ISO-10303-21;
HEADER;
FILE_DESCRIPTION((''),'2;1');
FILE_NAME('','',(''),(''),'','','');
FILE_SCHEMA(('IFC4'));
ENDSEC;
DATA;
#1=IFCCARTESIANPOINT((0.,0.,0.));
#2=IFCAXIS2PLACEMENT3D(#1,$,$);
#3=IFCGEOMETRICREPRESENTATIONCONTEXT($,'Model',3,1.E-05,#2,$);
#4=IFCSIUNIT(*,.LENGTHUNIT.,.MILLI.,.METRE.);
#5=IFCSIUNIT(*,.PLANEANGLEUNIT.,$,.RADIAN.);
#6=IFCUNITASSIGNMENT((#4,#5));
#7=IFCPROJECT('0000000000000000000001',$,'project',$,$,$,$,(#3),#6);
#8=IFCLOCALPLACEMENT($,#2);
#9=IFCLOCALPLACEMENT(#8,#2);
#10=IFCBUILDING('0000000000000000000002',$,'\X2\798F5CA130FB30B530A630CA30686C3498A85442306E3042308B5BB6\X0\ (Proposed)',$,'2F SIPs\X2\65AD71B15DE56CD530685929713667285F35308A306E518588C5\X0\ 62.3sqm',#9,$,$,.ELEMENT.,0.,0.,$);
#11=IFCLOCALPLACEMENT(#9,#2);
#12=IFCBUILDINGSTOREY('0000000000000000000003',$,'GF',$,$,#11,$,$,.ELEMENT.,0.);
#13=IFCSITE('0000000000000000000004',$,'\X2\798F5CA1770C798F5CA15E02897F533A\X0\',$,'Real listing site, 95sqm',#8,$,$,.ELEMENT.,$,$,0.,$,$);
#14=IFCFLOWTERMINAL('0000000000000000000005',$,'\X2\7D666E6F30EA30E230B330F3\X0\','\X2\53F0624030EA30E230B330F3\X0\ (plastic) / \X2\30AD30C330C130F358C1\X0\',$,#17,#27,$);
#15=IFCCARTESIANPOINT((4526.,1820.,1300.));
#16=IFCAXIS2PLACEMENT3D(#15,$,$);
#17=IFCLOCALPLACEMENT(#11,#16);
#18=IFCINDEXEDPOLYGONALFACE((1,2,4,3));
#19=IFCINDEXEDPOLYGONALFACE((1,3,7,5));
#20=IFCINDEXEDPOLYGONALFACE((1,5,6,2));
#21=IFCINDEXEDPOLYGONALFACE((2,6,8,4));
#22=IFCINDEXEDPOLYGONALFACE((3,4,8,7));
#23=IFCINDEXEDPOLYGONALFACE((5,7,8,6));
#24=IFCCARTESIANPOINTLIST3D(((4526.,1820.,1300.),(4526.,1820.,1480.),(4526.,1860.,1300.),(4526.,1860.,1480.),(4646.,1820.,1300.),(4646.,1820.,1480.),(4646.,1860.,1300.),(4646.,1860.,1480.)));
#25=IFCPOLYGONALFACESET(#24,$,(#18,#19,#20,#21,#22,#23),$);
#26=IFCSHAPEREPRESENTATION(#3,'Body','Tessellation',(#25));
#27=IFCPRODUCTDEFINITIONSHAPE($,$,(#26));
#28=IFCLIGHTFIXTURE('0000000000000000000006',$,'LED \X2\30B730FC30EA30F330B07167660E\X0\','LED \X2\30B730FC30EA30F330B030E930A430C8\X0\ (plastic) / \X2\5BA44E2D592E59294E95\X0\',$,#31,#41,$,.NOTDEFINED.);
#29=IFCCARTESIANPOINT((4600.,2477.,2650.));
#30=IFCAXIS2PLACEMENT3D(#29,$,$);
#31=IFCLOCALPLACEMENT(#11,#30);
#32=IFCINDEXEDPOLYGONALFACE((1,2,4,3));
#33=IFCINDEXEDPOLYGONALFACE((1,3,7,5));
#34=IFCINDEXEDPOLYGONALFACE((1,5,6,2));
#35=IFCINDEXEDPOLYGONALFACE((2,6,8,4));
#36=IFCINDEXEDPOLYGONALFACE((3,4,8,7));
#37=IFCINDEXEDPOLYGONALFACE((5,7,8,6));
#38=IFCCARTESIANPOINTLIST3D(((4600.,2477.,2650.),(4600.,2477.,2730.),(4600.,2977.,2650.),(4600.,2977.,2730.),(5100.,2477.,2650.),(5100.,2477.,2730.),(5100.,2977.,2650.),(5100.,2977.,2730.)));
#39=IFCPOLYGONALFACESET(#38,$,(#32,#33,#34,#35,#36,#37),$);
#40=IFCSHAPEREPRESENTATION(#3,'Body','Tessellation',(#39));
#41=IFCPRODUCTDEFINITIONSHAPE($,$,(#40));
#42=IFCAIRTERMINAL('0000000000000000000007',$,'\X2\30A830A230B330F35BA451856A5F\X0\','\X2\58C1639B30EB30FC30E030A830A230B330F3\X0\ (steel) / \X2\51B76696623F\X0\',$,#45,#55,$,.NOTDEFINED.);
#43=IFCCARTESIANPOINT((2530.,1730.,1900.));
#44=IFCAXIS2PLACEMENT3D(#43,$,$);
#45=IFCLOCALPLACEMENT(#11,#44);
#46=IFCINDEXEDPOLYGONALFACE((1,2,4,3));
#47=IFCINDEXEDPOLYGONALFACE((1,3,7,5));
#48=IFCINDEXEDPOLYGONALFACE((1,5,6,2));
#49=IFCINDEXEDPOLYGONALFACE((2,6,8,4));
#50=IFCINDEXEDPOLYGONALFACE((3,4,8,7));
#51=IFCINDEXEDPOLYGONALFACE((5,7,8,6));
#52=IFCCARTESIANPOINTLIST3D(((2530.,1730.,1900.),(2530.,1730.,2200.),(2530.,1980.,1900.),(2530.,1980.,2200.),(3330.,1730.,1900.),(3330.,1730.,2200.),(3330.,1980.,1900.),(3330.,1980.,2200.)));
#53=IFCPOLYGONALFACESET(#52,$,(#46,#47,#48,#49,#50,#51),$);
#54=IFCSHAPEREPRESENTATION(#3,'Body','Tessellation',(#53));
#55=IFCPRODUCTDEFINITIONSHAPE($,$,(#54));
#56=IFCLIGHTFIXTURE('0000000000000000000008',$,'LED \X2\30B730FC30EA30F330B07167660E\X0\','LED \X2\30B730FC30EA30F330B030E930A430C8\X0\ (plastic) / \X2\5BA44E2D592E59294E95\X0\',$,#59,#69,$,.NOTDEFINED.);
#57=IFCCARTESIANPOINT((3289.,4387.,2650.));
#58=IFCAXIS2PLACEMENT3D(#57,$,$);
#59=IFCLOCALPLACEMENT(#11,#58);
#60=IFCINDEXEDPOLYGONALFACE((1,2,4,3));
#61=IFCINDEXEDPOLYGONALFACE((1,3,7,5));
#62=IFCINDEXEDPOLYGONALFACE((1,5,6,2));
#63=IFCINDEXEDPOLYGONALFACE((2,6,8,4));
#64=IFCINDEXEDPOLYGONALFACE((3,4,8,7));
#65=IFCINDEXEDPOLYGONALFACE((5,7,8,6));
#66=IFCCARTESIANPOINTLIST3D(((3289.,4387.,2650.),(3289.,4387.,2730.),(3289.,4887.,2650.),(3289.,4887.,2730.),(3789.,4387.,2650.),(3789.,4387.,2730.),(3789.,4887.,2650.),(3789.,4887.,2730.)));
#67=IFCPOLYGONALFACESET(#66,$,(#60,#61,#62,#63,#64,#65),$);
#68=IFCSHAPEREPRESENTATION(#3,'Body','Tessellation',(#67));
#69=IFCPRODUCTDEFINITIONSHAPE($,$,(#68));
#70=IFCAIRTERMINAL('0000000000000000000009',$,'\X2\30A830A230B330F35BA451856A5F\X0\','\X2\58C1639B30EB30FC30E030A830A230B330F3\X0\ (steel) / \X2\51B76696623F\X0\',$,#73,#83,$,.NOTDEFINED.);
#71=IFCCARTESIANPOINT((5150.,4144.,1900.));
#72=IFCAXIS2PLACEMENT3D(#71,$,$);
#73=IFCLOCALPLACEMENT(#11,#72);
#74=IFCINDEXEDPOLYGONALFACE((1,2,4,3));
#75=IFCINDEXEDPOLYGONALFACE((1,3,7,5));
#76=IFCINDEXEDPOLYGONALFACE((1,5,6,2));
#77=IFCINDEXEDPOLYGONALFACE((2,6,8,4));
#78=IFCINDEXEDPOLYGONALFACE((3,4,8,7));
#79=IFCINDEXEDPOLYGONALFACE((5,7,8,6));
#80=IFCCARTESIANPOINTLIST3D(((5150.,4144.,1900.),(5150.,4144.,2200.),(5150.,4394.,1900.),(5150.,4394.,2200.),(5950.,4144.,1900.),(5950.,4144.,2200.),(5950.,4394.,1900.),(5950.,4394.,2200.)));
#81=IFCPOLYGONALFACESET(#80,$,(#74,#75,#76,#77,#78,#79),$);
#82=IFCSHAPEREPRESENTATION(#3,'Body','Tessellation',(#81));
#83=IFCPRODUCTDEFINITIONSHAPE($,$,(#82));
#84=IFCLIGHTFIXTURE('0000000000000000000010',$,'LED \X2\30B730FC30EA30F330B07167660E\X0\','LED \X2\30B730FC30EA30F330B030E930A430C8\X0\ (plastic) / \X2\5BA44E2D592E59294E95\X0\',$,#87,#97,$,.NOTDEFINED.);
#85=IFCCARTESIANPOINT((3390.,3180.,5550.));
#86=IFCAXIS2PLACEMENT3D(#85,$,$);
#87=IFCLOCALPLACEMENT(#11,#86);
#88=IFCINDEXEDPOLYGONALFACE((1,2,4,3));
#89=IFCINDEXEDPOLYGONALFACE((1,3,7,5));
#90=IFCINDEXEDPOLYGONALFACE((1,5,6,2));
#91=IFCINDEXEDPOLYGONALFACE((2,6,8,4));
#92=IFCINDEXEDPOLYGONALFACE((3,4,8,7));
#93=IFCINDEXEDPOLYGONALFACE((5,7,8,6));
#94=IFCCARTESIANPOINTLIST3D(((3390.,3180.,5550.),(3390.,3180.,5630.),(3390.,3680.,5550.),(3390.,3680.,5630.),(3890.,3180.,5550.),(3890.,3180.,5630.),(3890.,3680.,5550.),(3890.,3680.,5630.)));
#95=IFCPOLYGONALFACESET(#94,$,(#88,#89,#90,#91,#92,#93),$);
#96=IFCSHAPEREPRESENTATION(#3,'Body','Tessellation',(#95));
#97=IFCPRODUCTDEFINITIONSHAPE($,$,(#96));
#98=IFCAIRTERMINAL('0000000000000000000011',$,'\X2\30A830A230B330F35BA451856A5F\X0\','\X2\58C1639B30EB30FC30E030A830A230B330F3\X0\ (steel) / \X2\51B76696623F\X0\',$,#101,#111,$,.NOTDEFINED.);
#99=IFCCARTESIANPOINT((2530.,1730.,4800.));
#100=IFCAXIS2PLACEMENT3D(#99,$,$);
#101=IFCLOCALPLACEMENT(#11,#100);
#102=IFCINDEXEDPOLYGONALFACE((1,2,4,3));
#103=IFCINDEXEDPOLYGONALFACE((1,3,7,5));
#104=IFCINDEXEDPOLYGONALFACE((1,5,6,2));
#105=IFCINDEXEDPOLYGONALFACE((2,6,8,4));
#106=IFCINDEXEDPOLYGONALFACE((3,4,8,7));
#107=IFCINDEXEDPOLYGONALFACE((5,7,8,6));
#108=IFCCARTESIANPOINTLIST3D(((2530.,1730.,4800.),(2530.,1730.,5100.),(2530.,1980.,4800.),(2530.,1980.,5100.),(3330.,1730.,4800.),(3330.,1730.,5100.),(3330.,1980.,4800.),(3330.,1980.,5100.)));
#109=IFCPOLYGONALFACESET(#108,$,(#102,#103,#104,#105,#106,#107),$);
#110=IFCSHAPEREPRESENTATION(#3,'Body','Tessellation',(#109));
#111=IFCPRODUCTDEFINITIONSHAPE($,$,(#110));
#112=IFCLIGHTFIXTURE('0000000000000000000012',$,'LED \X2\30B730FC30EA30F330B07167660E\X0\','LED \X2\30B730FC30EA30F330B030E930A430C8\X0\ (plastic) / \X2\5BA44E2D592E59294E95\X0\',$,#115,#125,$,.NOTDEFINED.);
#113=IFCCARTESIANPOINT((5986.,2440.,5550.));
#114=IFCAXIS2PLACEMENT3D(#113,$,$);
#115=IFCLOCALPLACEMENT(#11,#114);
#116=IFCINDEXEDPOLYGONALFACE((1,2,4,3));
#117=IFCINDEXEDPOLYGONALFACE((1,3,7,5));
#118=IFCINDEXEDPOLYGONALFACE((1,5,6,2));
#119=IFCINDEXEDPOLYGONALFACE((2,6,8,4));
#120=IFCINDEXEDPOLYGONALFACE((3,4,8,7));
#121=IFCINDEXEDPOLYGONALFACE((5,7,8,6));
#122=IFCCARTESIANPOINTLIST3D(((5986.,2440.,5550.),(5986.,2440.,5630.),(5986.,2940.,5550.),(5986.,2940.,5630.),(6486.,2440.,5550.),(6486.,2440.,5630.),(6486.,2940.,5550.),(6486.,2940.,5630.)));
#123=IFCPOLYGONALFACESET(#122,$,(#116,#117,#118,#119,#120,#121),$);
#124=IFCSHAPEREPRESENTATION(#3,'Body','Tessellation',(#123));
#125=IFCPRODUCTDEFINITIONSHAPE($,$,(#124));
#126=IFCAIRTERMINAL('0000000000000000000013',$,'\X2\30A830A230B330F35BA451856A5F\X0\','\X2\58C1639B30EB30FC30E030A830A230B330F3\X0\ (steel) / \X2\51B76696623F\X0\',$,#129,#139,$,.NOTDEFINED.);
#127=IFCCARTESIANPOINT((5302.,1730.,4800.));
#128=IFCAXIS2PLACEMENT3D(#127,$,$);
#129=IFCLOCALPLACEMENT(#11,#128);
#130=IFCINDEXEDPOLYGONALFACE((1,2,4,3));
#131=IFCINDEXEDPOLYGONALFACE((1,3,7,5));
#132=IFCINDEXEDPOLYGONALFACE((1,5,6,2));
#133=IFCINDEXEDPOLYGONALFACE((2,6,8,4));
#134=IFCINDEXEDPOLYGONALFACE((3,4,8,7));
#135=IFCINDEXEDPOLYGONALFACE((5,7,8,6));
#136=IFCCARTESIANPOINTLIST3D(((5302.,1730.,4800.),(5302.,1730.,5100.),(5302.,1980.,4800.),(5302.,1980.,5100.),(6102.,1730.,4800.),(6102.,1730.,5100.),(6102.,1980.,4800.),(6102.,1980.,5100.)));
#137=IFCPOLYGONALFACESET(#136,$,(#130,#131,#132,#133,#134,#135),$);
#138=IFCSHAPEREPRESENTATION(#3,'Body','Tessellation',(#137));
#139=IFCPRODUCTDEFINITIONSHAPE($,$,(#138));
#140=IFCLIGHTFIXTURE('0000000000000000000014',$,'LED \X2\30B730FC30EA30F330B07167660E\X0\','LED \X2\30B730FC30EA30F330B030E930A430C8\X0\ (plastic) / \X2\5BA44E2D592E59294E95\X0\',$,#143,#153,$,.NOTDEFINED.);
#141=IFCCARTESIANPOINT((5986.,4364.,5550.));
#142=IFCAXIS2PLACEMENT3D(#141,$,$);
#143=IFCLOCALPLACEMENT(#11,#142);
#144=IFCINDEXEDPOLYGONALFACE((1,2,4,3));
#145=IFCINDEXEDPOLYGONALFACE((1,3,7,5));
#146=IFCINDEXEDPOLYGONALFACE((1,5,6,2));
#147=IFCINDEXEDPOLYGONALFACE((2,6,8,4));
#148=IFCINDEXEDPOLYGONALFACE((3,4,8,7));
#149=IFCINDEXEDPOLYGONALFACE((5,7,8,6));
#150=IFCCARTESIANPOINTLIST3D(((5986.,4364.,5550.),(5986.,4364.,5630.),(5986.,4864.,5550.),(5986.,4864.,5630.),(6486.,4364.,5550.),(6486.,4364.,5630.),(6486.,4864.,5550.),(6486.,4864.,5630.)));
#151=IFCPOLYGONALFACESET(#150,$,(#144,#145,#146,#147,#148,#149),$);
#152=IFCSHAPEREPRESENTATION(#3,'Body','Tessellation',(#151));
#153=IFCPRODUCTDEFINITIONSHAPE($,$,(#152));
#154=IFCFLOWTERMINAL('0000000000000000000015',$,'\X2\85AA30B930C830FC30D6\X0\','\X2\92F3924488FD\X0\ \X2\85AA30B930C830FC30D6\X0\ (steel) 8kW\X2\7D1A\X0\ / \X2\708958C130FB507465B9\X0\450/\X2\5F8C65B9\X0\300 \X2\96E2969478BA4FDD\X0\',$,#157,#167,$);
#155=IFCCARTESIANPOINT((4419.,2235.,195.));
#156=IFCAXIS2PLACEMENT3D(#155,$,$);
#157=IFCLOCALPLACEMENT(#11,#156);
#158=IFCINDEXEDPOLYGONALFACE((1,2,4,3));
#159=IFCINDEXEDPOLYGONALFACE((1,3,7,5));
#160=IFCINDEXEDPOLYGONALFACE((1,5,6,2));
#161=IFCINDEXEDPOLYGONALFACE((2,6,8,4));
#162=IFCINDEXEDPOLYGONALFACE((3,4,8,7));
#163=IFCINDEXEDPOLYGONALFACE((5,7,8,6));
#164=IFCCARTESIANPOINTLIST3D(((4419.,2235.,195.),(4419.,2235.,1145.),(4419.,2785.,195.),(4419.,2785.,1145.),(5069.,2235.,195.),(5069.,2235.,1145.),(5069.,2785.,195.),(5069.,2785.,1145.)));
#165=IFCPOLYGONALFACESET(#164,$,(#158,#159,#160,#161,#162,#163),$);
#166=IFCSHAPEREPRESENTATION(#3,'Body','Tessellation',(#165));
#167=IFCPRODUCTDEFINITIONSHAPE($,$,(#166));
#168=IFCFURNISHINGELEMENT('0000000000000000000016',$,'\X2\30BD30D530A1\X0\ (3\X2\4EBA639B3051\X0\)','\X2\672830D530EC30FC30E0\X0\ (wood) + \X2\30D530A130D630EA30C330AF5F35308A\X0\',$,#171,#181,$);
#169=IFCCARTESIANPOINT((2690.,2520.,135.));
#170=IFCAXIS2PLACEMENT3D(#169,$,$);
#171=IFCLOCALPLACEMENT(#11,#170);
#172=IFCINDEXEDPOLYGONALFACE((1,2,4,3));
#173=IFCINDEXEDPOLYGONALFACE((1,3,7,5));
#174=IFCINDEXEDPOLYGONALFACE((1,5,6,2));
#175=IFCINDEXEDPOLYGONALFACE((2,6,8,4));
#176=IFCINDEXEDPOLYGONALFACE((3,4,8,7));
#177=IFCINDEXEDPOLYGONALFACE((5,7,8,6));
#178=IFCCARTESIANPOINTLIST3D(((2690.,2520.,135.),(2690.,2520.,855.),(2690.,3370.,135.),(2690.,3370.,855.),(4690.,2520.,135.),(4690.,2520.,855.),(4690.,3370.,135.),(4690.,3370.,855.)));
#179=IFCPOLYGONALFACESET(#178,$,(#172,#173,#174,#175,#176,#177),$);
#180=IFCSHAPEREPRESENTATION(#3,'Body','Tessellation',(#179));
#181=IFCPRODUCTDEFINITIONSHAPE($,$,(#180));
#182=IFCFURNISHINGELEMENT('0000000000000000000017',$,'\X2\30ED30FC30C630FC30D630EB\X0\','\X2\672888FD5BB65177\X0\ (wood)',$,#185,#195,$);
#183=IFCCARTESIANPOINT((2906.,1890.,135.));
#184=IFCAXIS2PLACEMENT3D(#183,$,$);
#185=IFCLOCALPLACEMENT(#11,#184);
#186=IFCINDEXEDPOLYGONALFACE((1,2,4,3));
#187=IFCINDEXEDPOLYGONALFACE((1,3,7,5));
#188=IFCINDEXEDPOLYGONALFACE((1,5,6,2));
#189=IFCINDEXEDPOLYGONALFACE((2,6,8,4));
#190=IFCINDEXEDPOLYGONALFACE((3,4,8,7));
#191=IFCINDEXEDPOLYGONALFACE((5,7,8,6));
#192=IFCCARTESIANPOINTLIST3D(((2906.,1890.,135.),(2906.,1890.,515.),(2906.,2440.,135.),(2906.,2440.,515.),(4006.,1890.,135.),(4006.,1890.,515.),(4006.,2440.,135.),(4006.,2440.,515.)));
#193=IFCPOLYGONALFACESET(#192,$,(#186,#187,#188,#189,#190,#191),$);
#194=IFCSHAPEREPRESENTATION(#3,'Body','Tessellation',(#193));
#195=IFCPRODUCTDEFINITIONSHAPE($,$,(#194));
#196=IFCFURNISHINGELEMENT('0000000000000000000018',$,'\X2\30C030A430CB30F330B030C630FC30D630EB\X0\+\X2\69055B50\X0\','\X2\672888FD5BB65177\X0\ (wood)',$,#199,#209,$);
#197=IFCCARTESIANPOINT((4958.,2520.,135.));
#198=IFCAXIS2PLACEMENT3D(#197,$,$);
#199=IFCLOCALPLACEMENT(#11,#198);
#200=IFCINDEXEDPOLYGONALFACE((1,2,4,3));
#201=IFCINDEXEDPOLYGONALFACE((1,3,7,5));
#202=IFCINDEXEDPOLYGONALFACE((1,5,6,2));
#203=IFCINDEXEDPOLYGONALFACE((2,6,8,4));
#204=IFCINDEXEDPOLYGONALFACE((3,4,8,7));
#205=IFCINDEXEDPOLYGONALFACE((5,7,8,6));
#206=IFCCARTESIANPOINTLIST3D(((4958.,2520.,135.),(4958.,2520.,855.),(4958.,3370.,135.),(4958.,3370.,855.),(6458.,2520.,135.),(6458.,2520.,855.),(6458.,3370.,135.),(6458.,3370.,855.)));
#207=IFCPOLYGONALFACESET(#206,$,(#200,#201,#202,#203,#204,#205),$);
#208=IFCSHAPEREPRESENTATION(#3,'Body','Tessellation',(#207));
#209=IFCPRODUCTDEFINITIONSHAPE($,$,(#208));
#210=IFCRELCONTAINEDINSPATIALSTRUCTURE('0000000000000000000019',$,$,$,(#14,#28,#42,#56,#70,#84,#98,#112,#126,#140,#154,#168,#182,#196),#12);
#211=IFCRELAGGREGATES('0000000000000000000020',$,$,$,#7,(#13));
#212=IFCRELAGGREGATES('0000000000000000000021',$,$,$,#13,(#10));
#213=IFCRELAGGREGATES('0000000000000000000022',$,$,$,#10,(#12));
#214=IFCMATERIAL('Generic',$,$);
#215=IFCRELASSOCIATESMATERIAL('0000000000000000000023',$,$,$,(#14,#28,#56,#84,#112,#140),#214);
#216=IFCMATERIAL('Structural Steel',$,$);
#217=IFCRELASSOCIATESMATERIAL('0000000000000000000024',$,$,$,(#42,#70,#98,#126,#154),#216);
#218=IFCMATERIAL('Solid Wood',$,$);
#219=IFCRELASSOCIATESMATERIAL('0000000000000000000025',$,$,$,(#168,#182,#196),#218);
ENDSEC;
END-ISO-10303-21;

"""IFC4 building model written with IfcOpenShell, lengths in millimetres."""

from ifc_helpers import new_model, si_unit, frame, frame_2d, origin, place, context, project, spatial, rectangle, extrude, material, element, save


model = new_model("IFC4")

# Units and contexts
model_context = context("Model", 3, precision=1e-05, world=origin())
ifc_project = project(units=[si_unit("LENGTHUNIT", "METRE", prefix="MILLI"), si_unit("PLANEANGLEUNIT", "RADIAN")], contexts=[model_context])

# Site, building, storey
site_placement = place(None, origin())
site = spatial("IfcSite", under=ifc_project, at=site_placement, Name="福岡県福岡市西区", ObjectType="Real listing site, 95sqm", CompositionType="ELEMENT", RefElevation=0.0)
building_placement = place(site_placement, origin())
building = spatial("IfcBuilding", under=site, at=building_placement, Name="福岡・サウナと水風呂のある家 (Proposed)", ObjectType="2F SIPs断熱工法と天然木張りの内装 62.3sqm", CompositionType="ELEMENT", ElevationOfRefHeight=0.0, ElevationOfTerrain=0.0)
storey_placement = place(building_placement, origin())
storey = spatial("IfcBuildingStorey", under=building, at=storey_placement, Name="GF", CompositionType="ELEMENT", Elevation=0.0)

# Shared definitions
ifc_material_1 = material(Name="Solid Wood")

# Shared definitions
ifc_material_2 = material(Name="Structural Steel")

# Flow terminal
ifc_material_3 = material(Name="Generic")
flow_terminal_1_placement = place(storey_placement, frame((4526.0, 1820.0, 1300.0)))
element("IfcFlowTerminal", 1, at=flow_terminal_1_placement, inside=storey, material=ifc_material_3, Name="給湯リモコン", Description="台所リモコン (plastic) / キッチン壁", context=model_context, shape_type="SweptSolid", body=[
    extrude(rectangle(XDim=120.0, YDim=40.0, at=frame_2d((60.0, 20.0))), frame((4526.0, 1820.0, 1300.0)), (0.0, 0.0, 1.0), 180.0),
])

# Light fixture
light_fixture_1_placement = place(storey_placement, frame((4600.0, 2477.0, 2650.0)))
element("IfcLightFixture", 2, at=light_fixture_1_placement, inside=storey, material=ifc_material_3, Name="LED シーリング照明", Description="LED シーリングライト (plastic) / 室中央天井", PredefinedType="NOTDEFINED", context=model_context, shape_type="SweptSolid", body=[
    extrude(rectangle(XDim=500.0, YDim=500.0, at=frame_2d((250.0, 250.0))), frame((4600.0, 2477.0, 2650.0)), (0.0, 0.0, 1.0), 80.0),
])

# Air terminal
air_terminal_1_placement = place(storey_placement, frame((2530.0, 1730.0, 1900.0)))
element("IfcAirTerminal", 3, at=air_terminal_1_placement, inside=storey, material=ifc_material_2, Name="エアコン室内機", Description="壁掛ルームエアコン (steel) / 冷暖房", PredefinedType="NOTDEFINED", context=model_context, shape_type="SweptSolid", body=[
    extrude(rectangle(XDim=800.0, YDim=250.0, at=frame_2d((400.0, 125.0))), frame((2530.0, 1730.0, 1900.0)), (0.0, 0.0, 1.0), 300.0),
])

# Light fixture
light_fixture_2_placement = place(storey_placement, frame((3289.0, 4387.0, 2650.0)))
element("IfcLightFixture", 4, at=light_fixture_2_placement, inside=storey, material=ifc_material_3, Name="LED シーリング照明", Description="LED シーリングライト (plastic) / 室中央天井", PredefinedType="NOTDEFINED", context=model_context, shape_type="SweptSolid", body=[
    extrude(rectangle(XDim=500.0, YDim=500.0, at=frame_2d((250.0, 250.0))), frame((3289.0, 4387.0, 2650.0)), (0.0, 0.0, 1.0), 80.0),
])

# Air terminal
air_terminal_2_placement = place(storey_placement, frame((5150.0, 4144.0, 1900.0)))
element("IfcAirTerminal", 5, at=air_terminal_2_placement, inside=storey, material=ifc_material_2, Name="エアコン室内機", Description="壁掛ルームエアコン (steel) / 冷暖房", PredefinedType="NOTDEFINED", context=model_context, shape_type="SweptSolid", body=[
    extrude(rectangle(XDim=800.0, YDim=250.0, at=frame_2d((400.0, 125.0))), frame((5150.0, 4144.0, 1900.0)), (0.0, 0.0, 1.0), 300.0),
])

# Light fixture
light_fixture_3_placement = place(storey_placement, frame((3390.0, 3180.0, 5550.0)))
element("IfcLightFixture", 6, at=light_fixture_3_placement, inside=storey, material=ifc_material_3, Name="LED シーリング照明", Description="LED シーリングライト (plastic) / 室中央天井", PredefinedType="NOTDEFINED", context=model_context, shape_type="SweptSolid", body=[
    extrude(rectangle(XDim=500.0, YDim=500.0, at=frame_2d((250.0, 250.0))), frame((3390.0, 3180.0, 5550.0)), (0.0, 0.0, 1.0), 80.0),
])

# Air terminal
air_terminal_3_placement = place(storey_placement, frame((2530.0, 1730.0, 4800.0)))
element("IfcAirTerminal", 7, at=air_terminal_3_placement, inside=storey, material=ifc_material_2, Name="エアコン室内機", Description="壁掛ルームエアコン (steel) / 冷暖房", PredefinedType="NOTDEFINED", context=model_context, shape_type="SweptSolid", body=[
    extrude(rectangle(XDim=800.0, YDim=250.0, at=frame_2d((400.0, 125.0))), frame((2530.0, 1730.0, 4800.0)), (0.0, 0.0, 1.0), 300.0),
])

# Light fixture
light_fixture_4_placement = place(storey_placement, frame((5986.0, 2440.0, 5550.0)))
element("IfcLightFixture", 8, at=light_fixture_4_placement, inside=storey, material=ifc_material_3, Name="LED シーリング照明", Description="LED シーリングライト (plastic) / 室中央天井", PredefinedType="NOTDEFINED", context=model_context, shape_type="SweptSolid", body=[
    extrude(rectangle(XDim=500.0, YDim=500.0, at=frame_2d((250.0, 250.0))), frame((5986.0, 2440.0, 5550.0)), (0.0, 0.0, 1.0), 80.0),
])

# Air terminal
air_terminal_4_placement = place(storey_placement, frame((5302.0, 1730.0, 4800.0)))
element("IfcAirTerminal", 9, at=air_terminal_4_placement, inside=storey, material=ifc_material_2, Name="エアコン室内機", Description="壁掛ルームエアコン (steel) / 冷暖房", PredefinedType="NOTDEFINED", context=model_context, shape_type="SweptSolid", body=[
    extrude(rectangle(XDim=800.0, YDim=250.0, at=frame_2d((400.0, 125.0))), frame((5302.0, 1730.0, 4800.0)), (0.0, 0.0, 1.0), 300.0),
])

# Light fixture
light_fixture_5_placement = place(storey_placement, frame((5986.0, 4364.0, 5550.0)))
element("IfcLightFixture", 10, at=light_fixture_5_placement, inside=storey, material=ifc_material_3, Name="LED シーリング照明", Description="LED シーリングライト (plastic) / 室中央天井", PredefinedType="NOTDEFINED", context=model_context, shape_type="SweptSolid", body=[
    extrude(rectangle(XDim=500.0, YDim=500.0, at=frame_2d((250.0, 250.0))), frame((5986.0, 4364.0, 5550.0)), (0.0, 0.0, 1.0), 80.0),
])

# Flow terminal
flow_terminal_2_placement = place(storey_placement, frame((4419.0, 2235.0, 195.0)))
element("IfcFlowTerminal", 11, at=flow_terminal_2_placement, inside=storey, material=ifc_material_2, Name="薪ストーブ", Description="鋳鉄製 薪ストーブ (steel) 8kW級 / 炉壁・側方450/後方300 離隔確保", context=model_context, shape_type="SweptSolid", body=[
    extrude(rectangle(XDim=650.0, YDim=550.0, at=frame_2d((325.0, 275.0))), frame((4419.0, 2235.0, 195.0)), (0.0, 0.0, 1.0), 950.0),
])

# Furnishing elements
furnishing_1_placement = place(storey_placement, frame((2690.0, 2520.0, 135.0)))
element("IfcFurnishingElement", 12, at=furnishing_1_placement, inside=storey, material=ifc_material_1, Name="ソファ (3人掛け)", Description="木フレーム (wood) + ファブリック張り", context=model_context, shape_type="SweptSolid", body=[
    extrude(rectangle(XDim=2000.0, YDim=850.0, at=frame_2d((1000.0, 425.0))), frame((2690.0, 2520.0, 135.0)), (0.0, 0.0, 1.0), 720.0),
])
furnishing_2_placement = place(storey_placement, frame((2906.0, 1890.0, 135.0)))
element("IfcFurnishingElement", 13, at=furnishing_2_placement, inside=storey, material=ifc_material_1, Name="ローテーブル", Description="木製家具 (wood)", context=model_context, shape_type="SweptSolid", body=[
    extrude(rectangle(XDim=1100.0, YDim=550.0, at=frame_2d((550.0, 275.0))), frame((2906.0, 1890.0, 135.0)), (0.0, 0.0, 1.0), 380.0),
])
furnishing_3_placement = place(storey_placement, frame((4958.0, 2520.0, 135.0)))
element("IfcFurnishingElement", 14, at=furnishing_3_placement, inside=storey, material=ifc_material_1, Name="ダイニングテーブル+椅子", Description="木製家具 (wood)", context=model_context, shape_type="SweptSolid", body=[
    extrude(rectangle(XDim=1500.0, YDim=850.0, at=frame_2d((750.0, 425.0))), frame((4958.0, 2520.0, 135.0)), (0.0, 0.0, 1.0), 720.0),
])

save(model, "model.ifc")
